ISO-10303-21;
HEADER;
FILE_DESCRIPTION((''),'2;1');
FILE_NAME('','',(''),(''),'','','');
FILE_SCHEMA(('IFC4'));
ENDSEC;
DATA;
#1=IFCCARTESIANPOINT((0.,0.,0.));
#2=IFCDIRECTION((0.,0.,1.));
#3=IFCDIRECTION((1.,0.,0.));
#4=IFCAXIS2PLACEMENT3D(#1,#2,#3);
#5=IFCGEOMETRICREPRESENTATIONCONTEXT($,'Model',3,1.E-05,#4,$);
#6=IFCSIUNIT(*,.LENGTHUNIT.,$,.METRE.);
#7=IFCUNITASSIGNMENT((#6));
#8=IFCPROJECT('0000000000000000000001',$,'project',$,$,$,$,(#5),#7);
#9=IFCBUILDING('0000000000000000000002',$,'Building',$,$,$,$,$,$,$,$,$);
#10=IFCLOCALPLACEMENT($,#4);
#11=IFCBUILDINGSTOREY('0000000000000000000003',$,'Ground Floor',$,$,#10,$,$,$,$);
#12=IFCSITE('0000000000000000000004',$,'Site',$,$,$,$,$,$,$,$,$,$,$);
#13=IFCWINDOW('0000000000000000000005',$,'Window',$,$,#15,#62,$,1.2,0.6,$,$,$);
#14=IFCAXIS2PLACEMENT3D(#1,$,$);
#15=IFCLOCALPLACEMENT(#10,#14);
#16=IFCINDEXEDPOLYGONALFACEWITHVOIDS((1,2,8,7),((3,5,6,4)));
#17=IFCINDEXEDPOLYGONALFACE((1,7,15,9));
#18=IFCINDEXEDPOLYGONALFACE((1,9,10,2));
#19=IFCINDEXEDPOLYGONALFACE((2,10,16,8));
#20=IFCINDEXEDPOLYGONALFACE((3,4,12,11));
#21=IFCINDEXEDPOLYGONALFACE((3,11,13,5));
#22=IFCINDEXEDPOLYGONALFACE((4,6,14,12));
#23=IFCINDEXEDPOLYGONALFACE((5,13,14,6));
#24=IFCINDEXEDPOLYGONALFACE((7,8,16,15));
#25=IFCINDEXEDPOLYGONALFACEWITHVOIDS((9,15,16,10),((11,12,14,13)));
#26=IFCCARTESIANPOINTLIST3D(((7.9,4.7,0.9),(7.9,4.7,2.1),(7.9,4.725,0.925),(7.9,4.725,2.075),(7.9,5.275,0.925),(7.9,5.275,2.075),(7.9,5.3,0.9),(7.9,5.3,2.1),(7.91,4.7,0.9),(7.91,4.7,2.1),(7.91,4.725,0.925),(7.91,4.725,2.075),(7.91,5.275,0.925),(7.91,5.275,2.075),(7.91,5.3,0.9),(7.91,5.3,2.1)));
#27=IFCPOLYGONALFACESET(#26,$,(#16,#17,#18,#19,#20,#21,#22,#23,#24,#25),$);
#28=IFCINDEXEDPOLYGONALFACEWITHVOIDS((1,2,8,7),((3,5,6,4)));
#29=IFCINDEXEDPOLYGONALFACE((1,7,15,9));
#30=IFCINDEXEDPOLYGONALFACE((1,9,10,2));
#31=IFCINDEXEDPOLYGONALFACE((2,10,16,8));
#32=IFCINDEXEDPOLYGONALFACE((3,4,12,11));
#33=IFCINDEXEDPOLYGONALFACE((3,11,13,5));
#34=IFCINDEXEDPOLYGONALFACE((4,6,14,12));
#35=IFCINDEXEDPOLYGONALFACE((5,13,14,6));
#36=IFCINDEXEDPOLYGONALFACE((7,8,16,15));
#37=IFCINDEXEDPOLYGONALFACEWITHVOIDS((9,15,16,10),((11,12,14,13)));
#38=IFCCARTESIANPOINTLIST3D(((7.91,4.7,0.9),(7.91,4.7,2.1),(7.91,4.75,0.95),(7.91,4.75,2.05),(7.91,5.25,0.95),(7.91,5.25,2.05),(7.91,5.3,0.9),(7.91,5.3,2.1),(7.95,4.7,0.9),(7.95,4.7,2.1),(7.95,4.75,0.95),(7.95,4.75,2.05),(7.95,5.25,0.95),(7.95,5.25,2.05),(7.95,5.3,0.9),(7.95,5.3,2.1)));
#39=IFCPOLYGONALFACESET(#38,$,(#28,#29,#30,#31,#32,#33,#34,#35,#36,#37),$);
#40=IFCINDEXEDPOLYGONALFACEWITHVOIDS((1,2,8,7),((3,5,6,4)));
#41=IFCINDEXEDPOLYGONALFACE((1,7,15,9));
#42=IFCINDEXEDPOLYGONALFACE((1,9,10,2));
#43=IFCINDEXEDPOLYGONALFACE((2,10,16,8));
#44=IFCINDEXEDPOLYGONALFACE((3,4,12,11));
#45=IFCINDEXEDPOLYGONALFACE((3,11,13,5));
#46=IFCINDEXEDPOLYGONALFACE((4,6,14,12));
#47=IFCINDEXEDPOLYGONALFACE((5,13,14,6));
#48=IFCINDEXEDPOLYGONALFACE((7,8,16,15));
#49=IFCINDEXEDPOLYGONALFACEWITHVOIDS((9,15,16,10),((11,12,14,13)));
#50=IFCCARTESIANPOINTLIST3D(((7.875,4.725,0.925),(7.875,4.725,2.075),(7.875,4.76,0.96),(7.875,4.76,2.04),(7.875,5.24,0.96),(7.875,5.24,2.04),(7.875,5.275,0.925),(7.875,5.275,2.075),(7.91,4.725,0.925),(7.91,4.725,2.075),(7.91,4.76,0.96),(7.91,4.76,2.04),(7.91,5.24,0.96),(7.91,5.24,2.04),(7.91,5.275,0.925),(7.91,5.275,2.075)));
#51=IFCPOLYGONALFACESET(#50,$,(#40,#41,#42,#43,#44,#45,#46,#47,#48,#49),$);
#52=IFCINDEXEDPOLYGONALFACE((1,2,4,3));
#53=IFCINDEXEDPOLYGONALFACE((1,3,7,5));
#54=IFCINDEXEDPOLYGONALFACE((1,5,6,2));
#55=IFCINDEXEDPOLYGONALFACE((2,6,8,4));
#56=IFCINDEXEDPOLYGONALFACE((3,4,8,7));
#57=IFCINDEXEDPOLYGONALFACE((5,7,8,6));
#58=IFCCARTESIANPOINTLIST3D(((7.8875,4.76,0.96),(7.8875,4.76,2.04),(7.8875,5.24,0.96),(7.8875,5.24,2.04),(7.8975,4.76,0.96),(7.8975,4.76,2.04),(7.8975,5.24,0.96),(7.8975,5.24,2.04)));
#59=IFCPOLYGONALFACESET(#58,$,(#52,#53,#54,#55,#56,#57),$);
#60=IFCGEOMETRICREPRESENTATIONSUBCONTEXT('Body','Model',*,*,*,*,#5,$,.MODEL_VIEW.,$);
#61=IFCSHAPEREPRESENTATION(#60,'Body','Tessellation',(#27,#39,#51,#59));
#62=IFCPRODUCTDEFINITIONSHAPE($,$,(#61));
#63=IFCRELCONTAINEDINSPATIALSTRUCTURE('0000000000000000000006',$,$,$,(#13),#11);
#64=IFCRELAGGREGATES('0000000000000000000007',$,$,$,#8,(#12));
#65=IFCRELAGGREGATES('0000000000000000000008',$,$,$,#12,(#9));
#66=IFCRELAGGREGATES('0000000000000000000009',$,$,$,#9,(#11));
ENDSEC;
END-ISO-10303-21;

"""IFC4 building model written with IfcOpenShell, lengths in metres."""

from ifc_helpers import new_model, si_unit, frame, origin_with_axes, place, context, subcontext, project, spatial, line, indexed_curve, outline, extrude, element, save


model = new_model("IFC4")

# Units and contexts
model_context = context("Model", 3, precision=1e-05, world=origin_with_axes())
body_context = subcontext(model_context, "Body", "Model", "MODEL_VIEW")
ifc_project = project(units=[si_unit("LENGTHUNIT", "METRE")], contexts=[model_context])

# Site, building, storey
site = spatial("IfcSite", under=ifc_project, Name="Site")
building = spatial("IfcBuilding", under=site, Name="Building")
storey_placement = place(None, origin_with_axes())
storey = spatial("IfcBuildingStorey", under=building, at=storey_placement, Name="Ground Floor")

# Window
window_1_placement = place(storey_placement, frame((8.0, 4.7, 0.9), z_axis=(0.0, 0.0, 1.0), x_axis=(0.0, 1.0, 0.0)))
element("IfcWindow", 1, at=window_1_placement, inside=storey, Name="Window", OverallHeight=1.2, OverallWidth=0.6, context=body_context, shape_type="SweptSolid", body=[
    extrude(outline(indexed_curve([(0.0, 0.0), (0.6, 0.0), (0.6, 1.2), (0.0, 1.2)], segments=[line(1, 2, 3, 4, 1)]), holes=[indexed_curve([(0.025, 0.025), (0.575, 0.025), (0.575, 1.175), (0.025, 1.175)], segments=[line(1, 2, 3, 4, 1)])]), frame((0.0, 0.09, 0.0), z_axis=(0.0, -1.0, 0.0), x_axis=(1.0, 0.0, 0.0)), (0.0, 0.0, -1.0), 0.01),
    extrude(outline(indexed_curve([(0.0, 0.0), (0.6, 0.0), (0.6, 1.2), (0.0, 1.2)], segments=[line(1, 2, 3, 4, 1)]), holes=[indexed_curve([(0.05, 0.05), (0.55, 0.05), (0.55, 1.15), (0.05, 1.15)], segments=[line(1, 2, 3, 4, 1)])]), frame((0.0, 0.05, 0.0), z_axis=(0.0, -1.0, 0.0), x_axis=(1.0, 0.0, 0.0)), (0.0, 0.0, -1.0), 0.04),
    extrude(outline(indexed_curve([(0.0, 0.0), (0.55, 0.0), (0.55, 1.15), (0.0, 1.15)], segments=[line(1, 2, 3, 4, 1)]), holes=[indexed_curve([(0.035, 0.035), (0.515, 0.035), (0.515, 1.115), (0.035, 1.115)], segments=[line(1, 2, 3, 4, 1)])]), frame((0.025, 0.09, 0.025), z_axis=(0.0, -1.0, 0.0), x_axis=(1.0, 0.0, 0.0)), (0.0, 0.0, -1.0), 0.035),
    extrude(outline(indexed_curve([(0.035, 0.035), (0.515, 0.035), (0.515, 1.115), (0.035, 1.115)], segments=[line(1, 2, 3, 4, 1)])), frame((0.025, 0.1025, 0.025), z_axis=(0.0, -1.0, 0.0), x_axis=(1.0, 0.0, 0.0)), (0.0, 0.0, -1.0), 0.01),
])

save(model, "model.ifc")
